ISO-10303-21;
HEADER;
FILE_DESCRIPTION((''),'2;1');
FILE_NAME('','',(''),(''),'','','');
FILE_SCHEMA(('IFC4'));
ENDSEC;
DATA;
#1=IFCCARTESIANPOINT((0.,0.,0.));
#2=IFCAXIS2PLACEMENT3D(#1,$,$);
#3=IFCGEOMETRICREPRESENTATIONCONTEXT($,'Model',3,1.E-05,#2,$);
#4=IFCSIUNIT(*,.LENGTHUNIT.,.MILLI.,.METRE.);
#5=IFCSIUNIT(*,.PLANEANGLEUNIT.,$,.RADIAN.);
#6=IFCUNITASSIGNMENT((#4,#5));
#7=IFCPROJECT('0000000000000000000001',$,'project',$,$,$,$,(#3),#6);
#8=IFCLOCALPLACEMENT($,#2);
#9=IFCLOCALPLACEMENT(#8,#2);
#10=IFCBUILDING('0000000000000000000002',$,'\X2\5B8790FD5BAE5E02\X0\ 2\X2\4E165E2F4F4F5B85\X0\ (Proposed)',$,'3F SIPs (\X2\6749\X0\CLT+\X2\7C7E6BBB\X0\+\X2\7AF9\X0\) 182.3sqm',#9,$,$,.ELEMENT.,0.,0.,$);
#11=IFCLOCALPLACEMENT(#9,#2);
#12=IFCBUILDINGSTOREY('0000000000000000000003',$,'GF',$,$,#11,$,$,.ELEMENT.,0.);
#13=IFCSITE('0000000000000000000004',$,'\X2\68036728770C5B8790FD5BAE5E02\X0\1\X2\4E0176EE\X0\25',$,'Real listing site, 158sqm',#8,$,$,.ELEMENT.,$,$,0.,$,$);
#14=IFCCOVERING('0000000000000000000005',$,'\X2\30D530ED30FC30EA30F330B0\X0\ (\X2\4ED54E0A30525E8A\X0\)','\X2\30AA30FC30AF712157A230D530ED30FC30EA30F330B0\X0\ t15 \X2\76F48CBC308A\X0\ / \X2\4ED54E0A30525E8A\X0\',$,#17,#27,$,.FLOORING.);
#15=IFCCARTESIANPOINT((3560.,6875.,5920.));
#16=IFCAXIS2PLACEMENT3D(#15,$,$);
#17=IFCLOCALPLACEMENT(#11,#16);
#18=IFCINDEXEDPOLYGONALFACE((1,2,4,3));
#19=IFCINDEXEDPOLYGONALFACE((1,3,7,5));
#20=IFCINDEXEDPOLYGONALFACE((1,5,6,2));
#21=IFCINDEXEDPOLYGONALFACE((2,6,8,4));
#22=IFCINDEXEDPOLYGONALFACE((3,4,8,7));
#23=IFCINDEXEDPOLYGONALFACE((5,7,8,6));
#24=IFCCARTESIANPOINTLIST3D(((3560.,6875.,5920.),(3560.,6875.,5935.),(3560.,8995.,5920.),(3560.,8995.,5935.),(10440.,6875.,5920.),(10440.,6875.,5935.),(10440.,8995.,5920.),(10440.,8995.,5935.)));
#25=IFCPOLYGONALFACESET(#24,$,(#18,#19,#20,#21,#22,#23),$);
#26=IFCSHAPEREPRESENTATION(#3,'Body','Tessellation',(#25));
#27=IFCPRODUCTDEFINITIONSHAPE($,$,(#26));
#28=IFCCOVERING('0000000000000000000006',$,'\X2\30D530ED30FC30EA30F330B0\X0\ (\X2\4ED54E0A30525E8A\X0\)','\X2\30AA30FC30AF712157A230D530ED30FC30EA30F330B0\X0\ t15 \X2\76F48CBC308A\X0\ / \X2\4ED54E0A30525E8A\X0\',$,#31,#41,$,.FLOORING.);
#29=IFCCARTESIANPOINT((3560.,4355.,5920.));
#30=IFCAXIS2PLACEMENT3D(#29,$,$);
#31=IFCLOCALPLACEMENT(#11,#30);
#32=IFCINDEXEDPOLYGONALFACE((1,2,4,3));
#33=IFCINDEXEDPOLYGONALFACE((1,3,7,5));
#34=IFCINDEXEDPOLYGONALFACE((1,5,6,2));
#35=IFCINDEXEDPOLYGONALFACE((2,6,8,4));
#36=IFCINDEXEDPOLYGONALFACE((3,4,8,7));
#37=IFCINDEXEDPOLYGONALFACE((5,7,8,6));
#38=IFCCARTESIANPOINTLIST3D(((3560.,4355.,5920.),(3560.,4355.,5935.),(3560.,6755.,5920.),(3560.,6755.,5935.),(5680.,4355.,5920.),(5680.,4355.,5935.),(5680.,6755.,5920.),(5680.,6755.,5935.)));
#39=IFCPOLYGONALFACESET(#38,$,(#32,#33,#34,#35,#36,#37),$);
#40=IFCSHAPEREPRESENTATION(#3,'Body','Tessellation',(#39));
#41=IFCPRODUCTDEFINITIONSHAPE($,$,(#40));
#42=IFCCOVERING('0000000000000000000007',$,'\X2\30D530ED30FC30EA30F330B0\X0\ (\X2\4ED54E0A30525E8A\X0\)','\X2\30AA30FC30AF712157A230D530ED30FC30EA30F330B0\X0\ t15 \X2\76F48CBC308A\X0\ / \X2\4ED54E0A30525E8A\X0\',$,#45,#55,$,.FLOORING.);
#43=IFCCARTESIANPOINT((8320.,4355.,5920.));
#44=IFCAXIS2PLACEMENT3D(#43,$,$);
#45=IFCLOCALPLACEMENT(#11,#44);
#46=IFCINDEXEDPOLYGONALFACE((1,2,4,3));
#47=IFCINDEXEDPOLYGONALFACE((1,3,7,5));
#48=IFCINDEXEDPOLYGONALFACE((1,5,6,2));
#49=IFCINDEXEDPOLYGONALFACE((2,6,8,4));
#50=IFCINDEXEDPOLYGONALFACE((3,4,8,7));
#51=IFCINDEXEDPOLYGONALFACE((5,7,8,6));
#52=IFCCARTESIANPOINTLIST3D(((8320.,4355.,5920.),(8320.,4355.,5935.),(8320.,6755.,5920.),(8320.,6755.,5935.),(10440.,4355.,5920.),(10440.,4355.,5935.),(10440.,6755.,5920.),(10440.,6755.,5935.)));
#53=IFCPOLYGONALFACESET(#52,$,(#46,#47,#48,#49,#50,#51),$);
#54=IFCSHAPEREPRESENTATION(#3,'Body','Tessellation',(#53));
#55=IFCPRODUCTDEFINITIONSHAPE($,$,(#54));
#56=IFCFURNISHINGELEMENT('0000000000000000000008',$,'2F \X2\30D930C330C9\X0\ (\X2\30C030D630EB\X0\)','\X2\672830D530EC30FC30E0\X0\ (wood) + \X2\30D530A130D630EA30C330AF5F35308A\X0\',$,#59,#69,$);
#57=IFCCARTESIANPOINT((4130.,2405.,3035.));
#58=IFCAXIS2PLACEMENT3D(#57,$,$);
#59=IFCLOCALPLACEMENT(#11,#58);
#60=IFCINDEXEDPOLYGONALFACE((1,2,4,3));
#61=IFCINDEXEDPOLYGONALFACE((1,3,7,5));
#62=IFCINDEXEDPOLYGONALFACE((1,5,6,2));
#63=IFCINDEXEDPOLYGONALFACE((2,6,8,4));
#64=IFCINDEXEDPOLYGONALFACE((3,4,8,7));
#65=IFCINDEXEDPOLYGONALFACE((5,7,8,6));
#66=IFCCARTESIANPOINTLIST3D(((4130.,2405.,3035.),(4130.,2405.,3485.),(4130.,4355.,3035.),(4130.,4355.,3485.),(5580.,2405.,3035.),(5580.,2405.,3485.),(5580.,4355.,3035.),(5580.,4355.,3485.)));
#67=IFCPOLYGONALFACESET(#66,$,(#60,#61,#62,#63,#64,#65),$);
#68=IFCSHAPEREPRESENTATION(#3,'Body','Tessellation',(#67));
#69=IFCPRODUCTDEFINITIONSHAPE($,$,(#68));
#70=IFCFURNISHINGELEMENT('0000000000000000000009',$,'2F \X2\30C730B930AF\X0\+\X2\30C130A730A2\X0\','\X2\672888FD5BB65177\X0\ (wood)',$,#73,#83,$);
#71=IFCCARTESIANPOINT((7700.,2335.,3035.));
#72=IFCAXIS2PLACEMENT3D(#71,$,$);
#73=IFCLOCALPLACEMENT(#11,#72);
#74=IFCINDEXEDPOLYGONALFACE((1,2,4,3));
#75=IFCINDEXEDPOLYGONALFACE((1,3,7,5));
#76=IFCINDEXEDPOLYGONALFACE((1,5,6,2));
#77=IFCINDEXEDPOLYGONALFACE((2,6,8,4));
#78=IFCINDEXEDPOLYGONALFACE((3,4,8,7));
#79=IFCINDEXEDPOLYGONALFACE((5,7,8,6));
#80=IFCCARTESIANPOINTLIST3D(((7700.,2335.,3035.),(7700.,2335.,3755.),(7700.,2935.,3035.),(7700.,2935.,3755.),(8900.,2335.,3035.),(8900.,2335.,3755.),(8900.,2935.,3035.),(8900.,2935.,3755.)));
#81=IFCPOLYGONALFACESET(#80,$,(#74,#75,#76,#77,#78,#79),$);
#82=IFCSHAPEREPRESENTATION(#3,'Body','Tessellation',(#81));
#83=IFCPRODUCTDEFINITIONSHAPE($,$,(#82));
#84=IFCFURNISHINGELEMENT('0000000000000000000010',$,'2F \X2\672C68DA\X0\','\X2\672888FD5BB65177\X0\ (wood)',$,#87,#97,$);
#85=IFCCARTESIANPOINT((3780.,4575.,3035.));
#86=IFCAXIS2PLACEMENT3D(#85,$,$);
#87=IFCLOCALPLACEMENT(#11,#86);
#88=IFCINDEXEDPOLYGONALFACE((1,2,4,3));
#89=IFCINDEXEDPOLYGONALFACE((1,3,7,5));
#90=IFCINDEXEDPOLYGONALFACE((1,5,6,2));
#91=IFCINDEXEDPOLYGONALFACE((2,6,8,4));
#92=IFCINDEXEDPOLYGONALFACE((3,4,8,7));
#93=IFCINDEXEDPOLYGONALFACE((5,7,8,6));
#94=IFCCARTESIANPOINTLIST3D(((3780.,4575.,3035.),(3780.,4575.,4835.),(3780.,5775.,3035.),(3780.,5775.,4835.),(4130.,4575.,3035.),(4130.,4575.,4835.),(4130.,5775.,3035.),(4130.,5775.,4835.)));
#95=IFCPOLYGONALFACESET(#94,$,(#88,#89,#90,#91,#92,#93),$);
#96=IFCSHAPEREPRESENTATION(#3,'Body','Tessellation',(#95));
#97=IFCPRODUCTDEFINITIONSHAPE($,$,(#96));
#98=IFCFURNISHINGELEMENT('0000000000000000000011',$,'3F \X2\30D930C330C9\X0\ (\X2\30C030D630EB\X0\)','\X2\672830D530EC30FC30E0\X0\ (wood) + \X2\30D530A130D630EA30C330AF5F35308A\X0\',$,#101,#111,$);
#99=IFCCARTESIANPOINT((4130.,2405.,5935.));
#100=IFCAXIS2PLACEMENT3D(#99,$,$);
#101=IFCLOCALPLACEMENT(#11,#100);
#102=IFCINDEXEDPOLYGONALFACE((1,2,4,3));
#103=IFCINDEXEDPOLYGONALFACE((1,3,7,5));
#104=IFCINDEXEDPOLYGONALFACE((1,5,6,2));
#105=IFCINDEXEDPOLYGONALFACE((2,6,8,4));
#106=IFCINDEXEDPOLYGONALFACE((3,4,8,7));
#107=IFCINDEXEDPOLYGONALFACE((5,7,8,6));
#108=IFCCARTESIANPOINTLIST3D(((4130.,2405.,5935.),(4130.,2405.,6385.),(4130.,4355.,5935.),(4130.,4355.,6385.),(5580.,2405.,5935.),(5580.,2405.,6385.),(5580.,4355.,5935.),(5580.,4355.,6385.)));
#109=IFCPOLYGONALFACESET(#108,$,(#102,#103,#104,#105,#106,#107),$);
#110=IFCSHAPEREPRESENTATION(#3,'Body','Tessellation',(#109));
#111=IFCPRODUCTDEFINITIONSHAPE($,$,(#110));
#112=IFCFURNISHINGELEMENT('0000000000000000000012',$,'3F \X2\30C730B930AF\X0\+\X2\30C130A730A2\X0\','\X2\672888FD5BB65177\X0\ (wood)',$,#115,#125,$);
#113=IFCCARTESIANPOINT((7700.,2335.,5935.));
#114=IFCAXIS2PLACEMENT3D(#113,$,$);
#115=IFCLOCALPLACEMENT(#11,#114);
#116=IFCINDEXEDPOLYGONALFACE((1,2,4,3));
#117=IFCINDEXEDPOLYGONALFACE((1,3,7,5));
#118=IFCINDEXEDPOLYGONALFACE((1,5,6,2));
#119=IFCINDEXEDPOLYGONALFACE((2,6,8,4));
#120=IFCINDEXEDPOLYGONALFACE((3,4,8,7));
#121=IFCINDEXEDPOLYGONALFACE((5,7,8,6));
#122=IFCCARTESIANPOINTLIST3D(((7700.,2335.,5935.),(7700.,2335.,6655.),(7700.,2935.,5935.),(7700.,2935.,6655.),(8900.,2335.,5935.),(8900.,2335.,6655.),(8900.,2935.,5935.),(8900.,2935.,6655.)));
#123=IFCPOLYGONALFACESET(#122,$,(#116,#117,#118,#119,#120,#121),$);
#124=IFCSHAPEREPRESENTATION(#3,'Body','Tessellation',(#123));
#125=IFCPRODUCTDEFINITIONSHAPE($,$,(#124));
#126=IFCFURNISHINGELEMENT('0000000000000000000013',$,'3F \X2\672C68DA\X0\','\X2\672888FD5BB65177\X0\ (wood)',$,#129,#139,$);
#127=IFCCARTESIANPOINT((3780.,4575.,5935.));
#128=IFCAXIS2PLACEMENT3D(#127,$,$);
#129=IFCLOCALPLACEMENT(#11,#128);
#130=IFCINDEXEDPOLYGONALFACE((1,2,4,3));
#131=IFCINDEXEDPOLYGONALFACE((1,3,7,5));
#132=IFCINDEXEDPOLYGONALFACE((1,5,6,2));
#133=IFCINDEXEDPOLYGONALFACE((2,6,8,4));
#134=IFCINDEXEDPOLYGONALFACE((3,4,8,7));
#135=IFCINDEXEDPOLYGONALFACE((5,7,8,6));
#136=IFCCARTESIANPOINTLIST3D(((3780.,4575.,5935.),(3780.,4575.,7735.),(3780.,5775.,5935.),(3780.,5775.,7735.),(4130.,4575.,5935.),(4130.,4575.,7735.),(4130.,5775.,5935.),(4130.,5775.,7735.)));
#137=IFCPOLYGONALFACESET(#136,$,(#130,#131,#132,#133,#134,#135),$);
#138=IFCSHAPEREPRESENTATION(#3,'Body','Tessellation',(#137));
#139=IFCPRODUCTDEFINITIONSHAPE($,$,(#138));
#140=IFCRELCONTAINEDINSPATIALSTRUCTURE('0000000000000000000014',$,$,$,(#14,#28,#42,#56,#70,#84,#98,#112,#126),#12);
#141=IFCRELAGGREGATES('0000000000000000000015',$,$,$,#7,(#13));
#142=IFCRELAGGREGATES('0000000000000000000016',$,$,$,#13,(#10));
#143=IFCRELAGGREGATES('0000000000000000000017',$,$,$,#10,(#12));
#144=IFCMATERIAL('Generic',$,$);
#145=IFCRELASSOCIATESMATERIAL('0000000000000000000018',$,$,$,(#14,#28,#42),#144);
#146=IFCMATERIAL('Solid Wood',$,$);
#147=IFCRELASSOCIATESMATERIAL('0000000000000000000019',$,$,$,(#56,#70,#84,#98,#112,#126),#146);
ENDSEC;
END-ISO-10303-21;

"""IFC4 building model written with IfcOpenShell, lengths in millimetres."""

from ifc_helpers import new_model, si_unit, frame, frame_2d, origin, place, context, project, spatial, rectangle, extrude, material, element, save


model = new_model("IFC4")

# Units and contexts
model_context = context("Model", 3, precision=1e-05, world=origin())
ifc_project = project(units=[si_unit("LENGTHUNIT", "METRE", prefix="MILLI"), si_unit("PLANEANGLEUNIT", "RADIAN")], contexts=[model_context])

# Site, building, storey
site_placement = place(None, origin())
site = spatial("IfcSite", under=ifc_project, at=site_placement, Name="栃木県宇都宮市1丁目25", ObjectType="Real listing site, 158sqm", CompositionType="ELEMENT", RefElevation=0.0)
building_placement = place(site_placement, origin())
building = spatial("IfcBuilding", under=site, at=building_placement, Name="宇都宮市 2世帯住宅 (Proposed)", ObjectType="3F SIPs (杉CLT+籾殻+竹) 182.3sqm", CompositionType="ELEMENT", ElevationOfRefHeight=0.0, ElevationOfTerrain=0.0)
storey_placement = place(building_placement, origin())
storey = spatial("IfcBuildingStorey", under=building, at=storey_placement, Name="GF", CompositionType="ELEMENT", Elevation=0.0)

# Shared definitions
ifc_material_1 = material(Name="Solid Wood")

# Shared definitions
ifc_material_2 = material(Name="Generic")

# Coverings
covering_1_placement = place(storey_placement, frame((3560.0, 6875.0, 5920.0)))
element("IfcCovering", 1, at=covering_1_placement, inside=storey, material=ifc_material_2, Name="フローリング (仕上げ床)", Description="オーク無垢フローリング t15 直貼り / 仕上げ床", PredefinedType="FLOORING", context=model_context, shape_type="SweptSolid", body=[
    extrude(rectangle(XDim=6880.0, YDim=2120.0, at=frame_2d((3440.0, 1060.0))), frame((3560.0, 6875.0, 5920.0)), (0.0, 0.0, 1.0), 15.0),
])
covering_2_placement = place(storey_placement, frame((3560.0, 4355.0, 5920.0)))
element("IfcCovering", 2, at=covering_2_placement, inside=storey, material=ifc_material_2, Name="フローリング (仕上げ床)", Description="オーク無垢フローリング t15 直貼り / 仕上げ床", PredefinedType="FLOORING", context=model_context, shape_type="SweptSolid", body=[
    extrude(rectangle(XDim=2120.0, YDim=2400.0, at=frame_2d((1060.0, 1200.0))), frame((3560.0, 4355.0, 5920.0)), (0.0, 0.0, 1.0), 15.0),
])
covering_3_placement = place(storey_placement, frame((8320.0, 4355.0, 5920.0)))
element("IfcCovering", 3, at=covering_3_placement, inside=storey, material=ifc_material_2, Name="フローリング (仕上げ床)", Description="オーク無垢フローリング t15 直貼り / 仕上げ床", PredefinedType="FLOORING", context=model_context, shape_type="SweptSolid", body=[
    extrude(rectangle(XDim=2120.0, YDim=2400.0, at=frame_2d((1060.0, 1200.0))), frame((8320.0, 4355.0, 5920.0)), (0.0, 0.0, 1.0), 15.0),
])

# Furnishing elements
furnishing_1_placement = place(storey_placement, frame((4130.0, 2405.0, 3035.0)))
element("IfcFurnishingElement", 4, at=furnishing_1_placement, inside=storey, material=ifc_material_1, Name="2F ベッド (ダブル)", Description="木フレーム (wood) + ファブリック張り", context=model_context, shape_type="SweptSolid", body=[
    extrude(rectangle(XDim=1450.0, YDim=1950.0, at=frame_2d((725.0, 975.0))), frame((4130.0, 2405.0, 3035.0)), (0.0, 0.0, 1.0), 450.0),
])
furnishing_2_placement = place(storey_placement, frame((7700.0, 2335.0, 3035.0)))
element("IfcFurnishingElement", 5, at=furnishing_2_placement, inside=storey, material=ifc_material_1, Name="2F デスク+チェア", Description="木製家具 (wood)", context=model_context, shape_type="SweptSolid", body=[
    extrude(rectangle(XDim=1200.0, YDim=600.0, at=frame_2d((600.0, 300.0))), frame((7700.0, 2335.0, 3035.0)), (0.0, 0.0, 1.0), 720.0),
])
furnishing_3_placement = place(storey_placement, frame((3780.0, 4575.0, 3035.0)))
element("IfcFurnishingElement", 6, at=furnishing_3_placement, inside=storey, material=ifc_material_1, Name="2F 本棚", Description="木製家具 (wood)", context=model_context, shape_type="SweptSolid", body=[
    extrude(rectangle(XDim=350.0, YDim=1200.0, at=frame_2d((175.0, 600.0))), frame((3780.0, 4575.0, 3035.0)), (0.0, 0.0, 1.0), 1800.0),
])
furnishing_4_placement = place(storey_placement, frame((4130.0, 2405.0, 5935.0)))
element("IfcFurnishingElement", 7, at=furnishing_4_placement, inside=storey, material=ifc_material_1, Name="3F ベッド (ダブル)", Description="木フレーム (wood) + ファブリック張り", context=model_context, shape_type="SweptSolid", body=[
    extrude(rectangle(XDim=1450.0, YDim=1950.0, at=frame_2d((725.0, 975.0))), frame((4130.0, 2405.0, 5935.0)), (0.0, 0.0, 1.0), 450.0),
])
furnishing_5_placement = place(storey_placement, frame((7700.0, 2335.0, 5935.0)))
element("IfcFurnishingElement", 8, at=furnishing_5_placement, inside=storey, material=ifc_material_1, Name="3F デスク+チェア", Description="木製家具 (wood)", context=model_context, shape_type="SweptSolid", body=[
    extrude(rectangle(XDim=1200.0, YDim=600.0, at=frame_2d((600.0, 300.0))), frame((7700.0, 2335.0, 5935.0)), (0.0, 0.0, 1.0), 720.0),
])
furnishing_6_placement = place(storey_placement, frame((3780.0, 4575.0, 5935.0)))
element("IfcFurnishingElement", 9, at=furnishing_6_placement, inside=storey, material=ifc_material_1, Name="3F 本棚", Description="木製家具 (wood)", context=model_context, shape_type="SweptSolid", body=[
    extrude(rectangle(XDim=350.0, YDim=1200.0, at=frame_2d((175.0, 600.0))), frame((3780.0, 4575.0, 5935.0)), (0.0, 0.0, 1.0), 1800.0),
])

save(model, "model.ifc")
